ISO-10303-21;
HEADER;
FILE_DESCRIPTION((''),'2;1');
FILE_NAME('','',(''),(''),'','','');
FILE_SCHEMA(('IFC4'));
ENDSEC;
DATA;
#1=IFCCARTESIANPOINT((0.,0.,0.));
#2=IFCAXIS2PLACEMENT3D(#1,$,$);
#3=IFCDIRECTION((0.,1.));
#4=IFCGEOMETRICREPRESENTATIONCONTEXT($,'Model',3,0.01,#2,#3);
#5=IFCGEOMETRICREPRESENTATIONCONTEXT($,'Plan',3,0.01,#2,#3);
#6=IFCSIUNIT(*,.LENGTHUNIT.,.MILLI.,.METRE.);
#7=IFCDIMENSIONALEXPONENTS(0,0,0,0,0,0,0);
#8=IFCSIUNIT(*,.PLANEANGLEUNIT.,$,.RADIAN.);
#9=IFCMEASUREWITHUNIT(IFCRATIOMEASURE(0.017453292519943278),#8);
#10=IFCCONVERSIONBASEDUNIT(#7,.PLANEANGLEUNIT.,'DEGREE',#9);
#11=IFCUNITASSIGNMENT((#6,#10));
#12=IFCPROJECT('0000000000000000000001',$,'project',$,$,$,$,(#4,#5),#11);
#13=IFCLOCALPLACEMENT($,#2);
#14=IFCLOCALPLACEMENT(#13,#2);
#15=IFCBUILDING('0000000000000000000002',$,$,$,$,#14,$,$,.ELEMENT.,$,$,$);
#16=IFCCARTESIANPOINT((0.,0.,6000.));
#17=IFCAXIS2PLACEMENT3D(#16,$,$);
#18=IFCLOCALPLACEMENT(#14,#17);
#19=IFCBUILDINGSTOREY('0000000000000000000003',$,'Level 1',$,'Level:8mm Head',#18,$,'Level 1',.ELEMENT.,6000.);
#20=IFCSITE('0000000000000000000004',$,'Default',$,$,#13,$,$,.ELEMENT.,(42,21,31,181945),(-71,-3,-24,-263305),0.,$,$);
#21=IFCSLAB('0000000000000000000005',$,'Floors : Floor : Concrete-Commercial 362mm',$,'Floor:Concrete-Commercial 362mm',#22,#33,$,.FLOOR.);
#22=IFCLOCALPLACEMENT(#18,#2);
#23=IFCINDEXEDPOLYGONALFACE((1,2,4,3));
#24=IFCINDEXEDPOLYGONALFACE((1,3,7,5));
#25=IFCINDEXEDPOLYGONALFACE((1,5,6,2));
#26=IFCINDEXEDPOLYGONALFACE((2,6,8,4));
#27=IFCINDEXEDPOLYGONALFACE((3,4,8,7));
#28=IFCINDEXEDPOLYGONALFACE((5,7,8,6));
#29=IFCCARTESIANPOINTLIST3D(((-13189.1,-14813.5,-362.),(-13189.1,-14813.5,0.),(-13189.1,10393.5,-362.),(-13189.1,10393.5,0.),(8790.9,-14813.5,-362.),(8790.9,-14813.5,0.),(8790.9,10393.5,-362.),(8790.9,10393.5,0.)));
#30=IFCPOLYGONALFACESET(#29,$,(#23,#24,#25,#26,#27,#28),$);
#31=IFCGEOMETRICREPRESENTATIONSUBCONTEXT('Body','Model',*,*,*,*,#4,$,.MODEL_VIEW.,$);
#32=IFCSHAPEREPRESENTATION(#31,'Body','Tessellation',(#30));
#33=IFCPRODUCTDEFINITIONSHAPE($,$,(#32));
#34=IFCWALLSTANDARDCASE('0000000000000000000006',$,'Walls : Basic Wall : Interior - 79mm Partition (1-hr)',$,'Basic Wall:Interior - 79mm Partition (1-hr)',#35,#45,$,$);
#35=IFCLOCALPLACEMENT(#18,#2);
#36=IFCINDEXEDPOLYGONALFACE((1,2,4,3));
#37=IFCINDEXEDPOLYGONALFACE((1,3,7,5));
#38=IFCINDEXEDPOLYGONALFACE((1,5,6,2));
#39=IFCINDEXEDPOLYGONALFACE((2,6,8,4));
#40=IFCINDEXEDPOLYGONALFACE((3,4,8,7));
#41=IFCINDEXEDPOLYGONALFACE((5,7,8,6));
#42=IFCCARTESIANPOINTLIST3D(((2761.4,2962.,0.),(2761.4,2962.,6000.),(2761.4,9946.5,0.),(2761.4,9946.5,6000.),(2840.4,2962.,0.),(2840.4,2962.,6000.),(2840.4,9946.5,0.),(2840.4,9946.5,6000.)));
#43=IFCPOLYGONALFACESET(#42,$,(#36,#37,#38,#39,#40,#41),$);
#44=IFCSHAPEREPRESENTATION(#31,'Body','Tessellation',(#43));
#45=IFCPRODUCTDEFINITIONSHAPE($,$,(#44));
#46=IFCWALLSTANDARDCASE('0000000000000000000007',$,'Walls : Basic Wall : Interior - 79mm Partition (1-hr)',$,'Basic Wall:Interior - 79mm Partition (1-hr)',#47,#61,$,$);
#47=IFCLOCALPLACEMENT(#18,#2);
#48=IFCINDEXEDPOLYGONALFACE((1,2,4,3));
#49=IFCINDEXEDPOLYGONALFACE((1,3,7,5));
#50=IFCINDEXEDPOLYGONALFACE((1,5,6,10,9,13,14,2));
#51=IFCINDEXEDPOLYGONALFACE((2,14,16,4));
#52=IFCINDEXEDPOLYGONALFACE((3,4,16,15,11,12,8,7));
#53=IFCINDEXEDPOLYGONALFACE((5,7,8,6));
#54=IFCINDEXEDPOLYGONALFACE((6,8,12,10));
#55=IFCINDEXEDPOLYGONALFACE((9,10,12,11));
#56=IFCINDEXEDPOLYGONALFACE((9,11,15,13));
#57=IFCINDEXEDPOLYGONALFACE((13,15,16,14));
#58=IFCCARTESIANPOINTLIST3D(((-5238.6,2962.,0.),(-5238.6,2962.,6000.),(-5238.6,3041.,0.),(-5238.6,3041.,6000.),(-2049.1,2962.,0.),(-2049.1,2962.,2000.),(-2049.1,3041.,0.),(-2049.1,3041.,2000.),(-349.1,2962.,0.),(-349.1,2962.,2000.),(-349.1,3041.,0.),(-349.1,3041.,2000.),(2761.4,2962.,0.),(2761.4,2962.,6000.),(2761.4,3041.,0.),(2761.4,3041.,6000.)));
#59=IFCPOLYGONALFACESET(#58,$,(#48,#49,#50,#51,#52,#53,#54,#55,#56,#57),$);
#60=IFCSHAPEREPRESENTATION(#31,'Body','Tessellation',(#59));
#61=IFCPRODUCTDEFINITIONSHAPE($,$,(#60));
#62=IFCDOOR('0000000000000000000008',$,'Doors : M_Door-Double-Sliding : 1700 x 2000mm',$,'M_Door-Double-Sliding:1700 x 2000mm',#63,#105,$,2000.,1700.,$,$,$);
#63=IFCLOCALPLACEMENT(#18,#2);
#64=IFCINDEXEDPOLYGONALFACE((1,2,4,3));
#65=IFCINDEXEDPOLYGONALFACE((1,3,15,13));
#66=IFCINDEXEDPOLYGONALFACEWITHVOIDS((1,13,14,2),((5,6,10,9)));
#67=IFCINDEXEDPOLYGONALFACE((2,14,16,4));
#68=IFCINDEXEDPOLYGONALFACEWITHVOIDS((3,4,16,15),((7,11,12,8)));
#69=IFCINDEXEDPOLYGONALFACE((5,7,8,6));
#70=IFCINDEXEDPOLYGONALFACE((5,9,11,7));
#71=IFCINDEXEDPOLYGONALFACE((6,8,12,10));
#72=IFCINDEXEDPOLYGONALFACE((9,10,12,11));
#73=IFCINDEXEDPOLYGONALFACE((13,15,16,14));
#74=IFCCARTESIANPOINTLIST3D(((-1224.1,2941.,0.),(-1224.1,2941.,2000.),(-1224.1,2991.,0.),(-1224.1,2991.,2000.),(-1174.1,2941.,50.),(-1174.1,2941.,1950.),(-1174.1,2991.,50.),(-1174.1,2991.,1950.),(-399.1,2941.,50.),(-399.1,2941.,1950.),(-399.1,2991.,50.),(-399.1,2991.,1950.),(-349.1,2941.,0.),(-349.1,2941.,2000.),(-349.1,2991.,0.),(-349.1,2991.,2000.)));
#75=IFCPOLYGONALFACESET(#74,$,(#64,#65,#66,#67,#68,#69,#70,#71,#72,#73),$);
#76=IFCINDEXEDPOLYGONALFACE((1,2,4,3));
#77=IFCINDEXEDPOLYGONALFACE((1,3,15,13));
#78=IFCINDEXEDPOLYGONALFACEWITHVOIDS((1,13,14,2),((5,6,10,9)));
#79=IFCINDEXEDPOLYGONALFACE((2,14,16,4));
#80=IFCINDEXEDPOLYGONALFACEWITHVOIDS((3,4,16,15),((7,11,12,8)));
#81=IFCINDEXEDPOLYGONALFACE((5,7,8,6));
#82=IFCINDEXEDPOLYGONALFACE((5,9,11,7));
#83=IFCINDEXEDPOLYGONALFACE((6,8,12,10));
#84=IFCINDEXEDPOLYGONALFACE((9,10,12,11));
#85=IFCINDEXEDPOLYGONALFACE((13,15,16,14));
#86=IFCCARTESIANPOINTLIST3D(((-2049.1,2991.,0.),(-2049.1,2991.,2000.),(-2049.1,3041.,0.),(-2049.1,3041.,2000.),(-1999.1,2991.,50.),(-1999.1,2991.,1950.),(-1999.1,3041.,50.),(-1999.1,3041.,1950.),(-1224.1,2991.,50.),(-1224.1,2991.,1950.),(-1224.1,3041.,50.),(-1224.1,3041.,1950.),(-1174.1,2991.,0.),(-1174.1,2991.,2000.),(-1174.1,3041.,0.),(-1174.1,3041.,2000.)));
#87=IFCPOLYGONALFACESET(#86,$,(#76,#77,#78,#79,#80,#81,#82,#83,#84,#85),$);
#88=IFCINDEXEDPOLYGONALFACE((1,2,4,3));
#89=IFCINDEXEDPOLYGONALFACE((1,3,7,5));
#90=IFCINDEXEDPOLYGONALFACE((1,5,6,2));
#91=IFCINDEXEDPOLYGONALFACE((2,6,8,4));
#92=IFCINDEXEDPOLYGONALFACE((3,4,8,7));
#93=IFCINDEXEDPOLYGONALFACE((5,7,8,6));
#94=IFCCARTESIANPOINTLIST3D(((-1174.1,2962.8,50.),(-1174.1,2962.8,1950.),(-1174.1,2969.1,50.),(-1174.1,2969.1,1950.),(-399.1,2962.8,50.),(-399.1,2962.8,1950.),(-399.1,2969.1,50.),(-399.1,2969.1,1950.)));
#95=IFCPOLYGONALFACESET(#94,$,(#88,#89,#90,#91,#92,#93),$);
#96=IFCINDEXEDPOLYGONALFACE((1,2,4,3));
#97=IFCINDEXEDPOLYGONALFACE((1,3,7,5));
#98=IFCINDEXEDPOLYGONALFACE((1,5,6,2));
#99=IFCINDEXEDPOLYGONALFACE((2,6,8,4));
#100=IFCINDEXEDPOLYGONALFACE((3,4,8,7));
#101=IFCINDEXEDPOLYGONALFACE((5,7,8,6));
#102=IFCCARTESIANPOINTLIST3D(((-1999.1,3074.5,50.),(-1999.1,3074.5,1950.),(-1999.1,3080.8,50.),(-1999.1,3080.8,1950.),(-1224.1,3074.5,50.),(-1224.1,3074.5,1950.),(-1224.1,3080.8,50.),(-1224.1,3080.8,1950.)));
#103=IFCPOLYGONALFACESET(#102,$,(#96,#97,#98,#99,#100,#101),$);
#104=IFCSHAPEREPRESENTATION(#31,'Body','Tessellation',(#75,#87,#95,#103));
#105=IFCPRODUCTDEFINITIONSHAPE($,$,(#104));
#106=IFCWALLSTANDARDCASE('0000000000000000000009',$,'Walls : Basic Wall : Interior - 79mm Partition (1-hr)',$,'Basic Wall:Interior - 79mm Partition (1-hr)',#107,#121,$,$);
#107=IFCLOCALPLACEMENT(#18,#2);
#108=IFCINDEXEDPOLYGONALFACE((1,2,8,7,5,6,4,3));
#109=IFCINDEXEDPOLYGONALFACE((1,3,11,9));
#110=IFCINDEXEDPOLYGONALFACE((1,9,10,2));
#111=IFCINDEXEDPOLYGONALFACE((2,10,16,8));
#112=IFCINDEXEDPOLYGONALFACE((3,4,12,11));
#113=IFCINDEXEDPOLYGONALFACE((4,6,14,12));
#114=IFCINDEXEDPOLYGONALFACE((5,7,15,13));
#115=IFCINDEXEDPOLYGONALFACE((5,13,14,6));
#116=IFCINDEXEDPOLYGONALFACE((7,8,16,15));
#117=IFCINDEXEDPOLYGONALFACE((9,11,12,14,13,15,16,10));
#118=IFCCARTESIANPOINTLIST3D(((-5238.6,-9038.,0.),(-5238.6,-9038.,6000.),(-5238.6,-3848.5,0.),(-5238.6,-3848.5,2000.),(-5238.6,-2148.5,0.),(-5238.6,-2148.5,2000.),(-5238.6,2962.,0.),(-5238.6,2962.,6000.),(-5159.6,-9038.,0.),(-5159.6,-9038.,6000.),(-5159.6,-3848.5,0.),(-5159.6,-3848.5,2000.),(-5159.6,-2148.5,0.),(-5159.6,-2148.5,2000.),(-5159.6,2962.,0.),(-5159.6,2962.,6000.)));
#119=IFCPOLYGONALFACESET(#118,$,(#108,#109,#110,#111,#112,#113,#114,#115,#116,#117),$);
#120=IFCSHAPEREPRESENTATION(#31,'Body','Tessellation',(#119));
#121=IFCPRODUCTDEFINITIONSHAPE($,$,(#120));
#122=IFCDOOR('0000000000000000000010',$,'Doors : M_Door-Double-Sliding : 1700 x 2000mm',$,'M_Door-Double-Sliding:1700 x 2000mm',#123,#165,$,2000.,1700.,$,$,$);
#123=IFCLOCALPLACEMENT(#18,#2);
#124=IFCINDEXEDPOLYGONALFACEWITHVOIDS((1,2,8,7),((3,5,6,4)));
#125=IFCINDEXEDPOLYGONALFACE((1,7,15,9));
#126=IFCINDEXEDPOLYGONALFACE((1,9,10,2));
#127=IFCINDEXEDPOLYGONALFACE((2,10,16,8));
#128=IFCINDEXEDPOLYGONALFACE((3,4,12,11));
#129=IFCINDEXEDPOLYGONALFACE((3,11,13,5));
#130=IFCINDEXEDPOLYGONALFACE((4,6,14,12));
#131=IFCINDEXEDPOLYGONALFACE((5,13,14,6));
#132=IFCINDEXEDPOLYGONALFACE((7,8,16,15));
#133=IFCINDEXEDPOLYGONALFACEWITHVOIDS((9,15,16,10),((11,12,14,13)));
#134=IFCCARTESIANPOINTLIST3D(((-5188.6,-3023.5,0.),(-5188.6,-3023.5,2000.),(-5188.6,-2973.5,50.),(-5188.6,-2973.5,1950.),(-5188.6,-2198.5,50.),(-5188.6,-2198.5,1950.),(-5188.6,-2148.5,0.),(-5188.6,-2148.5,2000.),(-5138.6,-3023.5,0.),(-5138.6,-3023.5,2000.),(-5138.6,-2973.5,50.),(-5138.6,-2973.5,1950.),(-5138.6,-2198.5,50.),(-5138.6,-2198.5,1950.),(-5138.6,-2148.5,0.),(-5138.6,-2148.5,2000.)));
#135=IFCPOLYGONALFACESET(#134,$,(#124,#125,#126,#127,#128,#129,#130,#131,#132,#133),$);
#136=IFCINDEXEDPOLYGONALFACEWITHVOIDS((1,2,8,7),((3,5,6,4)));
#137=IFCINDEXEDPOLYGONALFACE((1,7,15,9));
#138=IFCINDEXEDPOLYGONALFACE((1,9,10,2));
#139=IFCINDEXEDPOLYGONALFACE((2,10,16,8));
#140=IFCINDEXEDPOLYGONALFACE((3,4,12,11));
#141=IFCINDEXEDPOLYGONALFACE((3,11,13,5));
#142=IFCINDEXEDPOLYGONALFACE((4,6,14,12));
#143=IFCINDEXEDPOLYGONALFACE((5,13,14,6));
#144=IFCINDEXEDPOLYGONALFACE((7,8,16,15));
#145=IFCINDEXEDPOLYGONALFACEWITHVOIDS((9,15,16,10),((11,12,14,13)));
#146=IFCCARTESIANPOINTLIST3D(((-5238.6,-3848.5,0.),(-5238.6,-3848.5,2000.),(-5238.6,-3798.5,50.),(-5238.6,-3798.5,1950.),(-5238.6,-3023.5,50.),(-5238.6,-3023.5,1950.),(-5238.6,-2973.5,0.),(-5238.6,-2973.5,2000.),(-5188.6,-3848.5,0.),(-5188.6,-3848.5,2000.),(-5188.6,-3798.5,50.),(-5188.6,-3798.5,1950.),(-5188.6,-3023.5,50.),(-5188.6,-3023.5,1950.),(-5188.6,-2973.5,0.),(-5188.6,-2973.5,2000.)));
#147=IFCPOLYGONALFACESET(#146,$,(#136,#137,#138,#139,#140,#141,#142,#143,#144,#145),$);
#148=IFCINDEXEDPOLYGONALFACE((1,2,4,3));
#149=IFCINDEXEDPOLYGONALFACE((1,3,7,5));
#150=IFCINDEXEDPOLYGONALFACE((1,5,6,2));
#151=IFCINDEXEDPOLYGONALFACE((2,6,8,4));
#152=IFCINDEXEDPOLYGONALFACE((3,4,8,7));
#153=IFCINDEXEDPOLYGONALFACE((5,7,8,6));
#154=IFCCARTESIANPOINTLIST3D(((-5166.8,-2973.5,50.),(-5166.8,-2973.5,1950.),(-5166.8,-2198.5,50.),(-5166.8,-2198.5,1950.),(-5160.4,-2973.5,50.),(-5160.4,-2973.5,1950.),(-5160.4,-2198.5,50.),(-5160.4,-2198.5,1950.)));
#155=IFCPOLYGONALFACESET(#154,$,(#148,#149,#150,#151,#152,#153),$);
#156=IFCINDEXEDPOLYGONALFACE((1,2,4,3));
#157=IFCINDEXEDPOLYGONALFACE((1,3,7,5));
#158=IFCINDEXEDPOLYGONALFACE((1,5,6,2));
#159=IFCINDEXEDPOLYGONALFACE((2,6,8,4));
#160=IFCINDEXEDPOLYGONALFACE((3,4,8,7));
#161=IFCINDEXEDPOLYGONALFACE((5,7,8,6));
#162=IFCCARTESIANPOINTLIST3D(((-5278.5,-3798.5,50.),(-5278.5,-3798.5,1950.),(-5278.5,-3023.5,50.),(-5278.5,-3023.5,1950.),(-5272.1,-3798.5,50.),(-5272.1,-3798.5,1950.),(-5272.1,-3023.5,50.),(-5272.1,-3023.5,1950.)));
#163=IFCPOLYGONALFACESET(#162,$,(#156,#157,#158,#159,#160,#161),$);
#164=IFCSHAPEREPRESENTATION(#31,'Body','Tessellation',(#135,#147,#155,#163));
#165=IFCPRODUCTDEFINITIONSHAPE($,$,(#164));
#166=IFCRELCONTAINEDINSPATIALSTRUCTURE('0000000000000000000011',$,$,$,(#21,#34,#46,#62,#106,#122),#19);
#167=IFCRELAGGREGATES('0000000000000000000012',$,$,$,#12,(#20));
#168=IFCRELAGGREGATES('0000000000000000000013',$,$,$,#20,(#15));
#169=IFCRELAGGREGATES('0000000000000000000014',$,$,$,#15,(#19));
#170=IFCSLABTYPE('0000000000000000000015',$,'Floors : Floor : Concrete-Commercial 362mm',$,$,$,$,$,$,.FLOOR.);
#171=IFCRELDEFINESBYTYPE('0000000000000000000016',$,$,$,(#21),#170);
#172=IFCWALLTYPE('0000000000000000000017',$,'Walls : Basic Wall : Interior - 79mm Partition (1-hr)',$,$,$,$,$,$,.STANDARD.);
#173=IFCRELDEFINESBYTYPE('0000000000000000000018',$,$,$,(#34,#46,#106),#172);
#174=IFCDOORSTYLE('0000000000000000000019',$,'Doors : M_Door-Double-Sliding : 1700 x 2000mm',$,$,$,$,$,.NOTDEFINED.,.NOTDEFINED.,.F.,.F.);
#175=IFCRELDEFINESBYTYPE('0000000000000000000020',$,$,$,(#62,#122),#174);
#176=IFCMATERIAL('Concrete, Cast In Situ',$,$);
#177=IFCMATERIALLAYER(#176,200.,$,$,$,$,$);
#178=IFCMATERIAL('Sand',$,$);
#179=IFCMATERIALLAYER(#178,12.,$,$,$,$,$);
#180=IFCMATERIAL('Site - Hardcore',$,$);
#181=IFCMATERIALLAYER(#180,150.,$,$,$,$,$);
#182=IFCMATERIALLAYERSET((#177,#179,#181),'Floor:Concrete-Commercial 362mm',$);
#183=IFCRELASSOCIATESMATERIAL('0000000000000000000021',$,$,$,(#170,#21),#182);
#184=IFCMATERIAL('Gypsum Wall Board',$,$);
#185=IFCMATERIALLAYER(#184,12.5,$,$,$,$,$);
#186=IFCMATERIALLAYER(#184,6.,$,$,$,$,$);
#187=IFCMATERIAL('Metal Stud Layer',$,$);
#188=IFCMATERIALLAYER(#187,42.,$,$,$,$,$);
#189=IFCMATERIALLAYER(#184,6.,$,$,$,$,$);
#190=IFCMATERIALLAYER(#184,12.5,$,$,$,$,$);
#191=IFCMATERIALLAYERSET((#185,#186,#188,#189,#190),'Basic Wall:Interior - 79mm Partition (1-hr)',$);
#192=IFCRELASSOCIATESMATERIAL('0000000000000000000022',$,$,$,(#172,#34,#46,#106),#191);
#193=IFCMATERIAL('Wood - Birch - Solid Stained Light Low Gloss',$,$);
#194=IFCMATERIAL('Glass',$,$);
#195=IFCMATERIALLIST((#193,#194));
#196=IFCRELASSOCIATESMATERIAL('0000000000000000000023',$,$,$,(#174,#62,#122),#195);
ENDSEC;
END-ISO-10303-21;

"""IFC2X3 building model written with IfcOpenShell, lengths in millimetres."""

from ifc_helpers import new_model, entity, si_unit, converted_unit, direction, frame, frame_2d, origin, origin_2d_with_axis, place, context, subcontext, project, spatial, polyline, rectangle, outline, extrude, source, transform, mapped, material, material_list, layer, layer_set, layer_usage, type_object, type_shapes, element, fill, save


model = new_model("IFC2X3")

# Units and contexts
model_context = context("Model", 3, precision=0.01, world=origin(), true_north=direction((0.0, 1.0)))
plan_context = context("Plan", 3, precision=0.01, world=origin(), true_north=direction((0.0, 1.0)))
body_context = subcontext(model_context, "Body", "Model", "MODEL_VIEW")
ifc_project = project(units=[si_unit("LENGTHUNIT", "METRE", prefix="MILLI"), converted_unit("PLANEANGLEUNIT", "DEGREE", entity("IfcRatioMeasure", 0.017453292519943278), si_unit("PLANEANGLEUNIT", "RADIAN"), dimensions=[0, 0, 0, 0, 0, 0, 0])], contexts=[model_context, plan_context])

# Site, building, storey
site_placement = place(None, origin())
site = spatial("IfcSite", under=ifc_project, at=site_placement, Name="Default", CompositionType="ELEMENT", RefLatitude=(42, 21, 31, 181945), RefLongitude=(-71, -3, -24, -263305), RefElevation=0.0)
building_placement = place(site_placement, origin())
building = spatial("IfcBuilding", under=site, at=building_placement, CompositionType="ELEMENT")
storey_placement = place(building_placement, frame((0.0, 0.0, 6000.0)))
storey = spatial("IfcBuildingStorey", under=building, at=storey_placement, Name="Level 1", ObjectType="Level:8mm Head", LongName="Level 1", CompositionType="ELEMENT", Elevation=6000.0)

# Slab
ifc_material_1 = material(Name="Concrete, Cast In Situ")
ifc_layer_1 = layer(ifc_material_1, 200.0)
ifc_material_2 = material(Name="Sand")
ifc_layer_2 = layer(ifc_material_2, 12.0)
ifc_material_3 = material(Name="Site - Hardcore")
ifc_layer_3 = layer(ifc_material_3, 150.0)
ifc_layer_set_1 = layer_set([ifc_layer_1, ifc_layer_2, ifc_layer_3], Name="Floor:Concrete-Commercial 362mm")
ifc_layer_usage_1 = layer_usage(ifc_layer_set_1, "AXIS3", "POSITIVE", 0.0)
slab_type = type_object("IfcSlabType", Name="Floors : Floor : Concrete-Commercial 362mm", PredefinedType="FLOOR", material=ifc_layer_set_1)
slab_placement = place(storey_placement, origin())
element("IfcSlab", 1, at=slab_placement, inside=storey, type_object=slab_type, material=ifc_layer_usage_1, Name="Floors : Floor : Concrete-Commercial 362mm", ObjectType="Floor:Concrete-Commercial 362mm", PredefinedType="FLOOR", context=body_context, shape_type="SweptSolid", body=[
    extrude(rectangle(XDim=25207.0, YDim=21980.0, at=frame_2d((0.0, 0.0), x_axis=(1.0, 0.0))), frame((-2199.1, -2210.0, 0.0), z_axis=(0.0, 0.0, -1.0), x_axis=(0.0, 1.0, 0.0)), (0.0, 0.0, 1.0), 362.0),
])

# Wall
ifc_material_4 = material(Name="Gypsum Wall Board")
ifc_layer_4 = layer(ifc_material_4, 12.5)
ifc_layer_5 = layer(ifc_material_4, 6.0)
ifc_material_5 = material(Name="Metal Stud Layer")
ifc_layer_6 = layer(ifc_material_5, 42.0)
ifc_layer_7 = layer(ifc_material_4, 6.0)
ifc_layer_8 = layer(ifc_material_4, 12.5)
ifc_layer_set_2 = layer_set([ifc_layer_4, ifc_layer_5, ifc_layer_6, ifc_layer_7, ifc_layer_8], Name="Basic Wall:Interior - 79mm Partition (1-hr)")
ifc_layer_usage_2 = layer_usage(ifc_layer_set_2, "AXIS2", "NEGATIVE", 39.5)
wall_type = type_object("IfcWallType", Name="Walls : Basic Wall : Interior - 79mm Partition (1-hr)", PredefinedType="STANDARD", material=ifc_layer_set_2)
wall_1_placement = place(storey_placement, frame((2800.9, 9946.5, 0.0), z_axis=(0.0, 0.0, 1.0), x_axis=(0.0, -1.0, 0.0)))
element("IfcWallStandardCase", 2, at=wall_1_placement, inside=storey, type_object=wall_type, material=ifc_layer_usage_2, Name="Walls : Basic Wall : Interior - 79mm Partition (1-hr)", ObjectType="Basic Wall:Interior - 79mm Partition (1-hr)", context=body_context, shape_type="SweptSolid", body=[
    extrude(rectangle(XDim=6984.5, YDim=79.0, at=frame_2d((3492.3, 0.0), x_axis=(-1.0, 0.0))), origin(), (0.0, 0.0, 1.0), 6000.0),
])

# Walls, openings, doors
wall_2_placement = place(storey_placement, frame((2761.4, 3001.5, 0.0), z_axis=(0.0, 0.0, 1.0), x_axis=(-1.0, 0.0, 0.0)))
wall_2 = element("IfcWallStandardCase", 3, at=wall_2_placement, inside=storey, type_object=wall_type, material=ifc_layer_usage_2, Name="Walls : Basic Wall : Interior - 79mm Partition (1-hr)", ObjectType="Basic Wall:Interior - 79mm Partition (1-hr)", context=body_context, shape_type="SweptSolid", body=[
    extrude(rectangle(XDim=8000.0, YDim=79.0, at=frame_2d((4000.0, 0.0), x_axis=(-1.0, 0.0))), origin(), (0.0, 0.0, 1.0), 6000.0),
])
opening_1_placement = place(wall_2_placement, frame((4810.5, 39.5, 0.0)))
opening_1 = element("IfcOpeningElement", 4, at=opening_1_placement, cuts=wall_2, ObjectType="Opening", context=body_context, shape_type="SweptSolid", body=[
    extrude(rectangle(XDim=2000.0, YDim=1700.0, at=frame_2d((1000.0, 850.0), x_axis=(-1.0, 0.0))), frame((0.0, 0.0, 0.0), z_axis=(0.0, -1.0, 0.0), x_axis=(0.0, 0.0, 1.0)), (0.0, 0.0, 1.0), 79.0),
])
ifc_material_6 = material(Name="Wood - Birch - Solid Stained Light Low Gloss")
ifc_material_7 = material(Name="Glass")
ifc_material_list = material_list([ifc_material_6, ifc_material_7])
door_style = type_object("IfcDoorStyle", Name="Doors : M_Door-Double-Sliding : 1700 x 2000mm", ConstructionType="NOTDEFINED", OperationType="NOTDEFINED", ParameterTakesPrecedence=False, Sizeable=False, material=ifc_material_list)
shared_shape_1 = source(origin(), body_context, "Body", "SweptSolid", [
    extrude(outline(polyline([(-437.5, -1000.0), (437.5, -1000.0), (437.5, 1000.0), (-437.5, 1000.0), (-437.5, -1000.0)]), holes=[polyline([(-387.5, -950.0), (-387.5, 950.0), (387.5, 950.0), (387.5, -950.0), (-387.5, -950.0)])]), frame((1262.5, -21.0, 1000.0), z_axis=(0.0, 1.0, 0.0), x_axis=(1.0, 0.0, 0.0)), (0.0, 0.0, 1.0), 50.0),
    extrude(outline(polyline([(-1000.0, -437.5), (1000.0, -437.5), (1000.0, 437.5), (-1000.0, 437.5), (-1000.0, -437.5)]), holes=[polyline([(-950.0, -387.5), (-950.0, 387.5), (950.0, 387.5), (950.0, -387.5), (-950.0, -387.5)])]), frame((437.5, 29.0, 1000.0), z_axis=(0.0, 1.0, 0.0), x_axis=(0.0, 0.0, -1.0)), (0.0, 0.0, 1.0), 50.0),
    extrude(rectangle(XDim=6.3, YDim=775.0, at=frame_2d((0.0, 0.0), x_axis=(1.0, 0.0))), frame((1262.5, 4.0, 50.0), z_axis=(0.0, 0.0, 1.0), x_axis=(0.0, -1.0, 0.0)), (0.0, 0.0, 1.0), 1900.0),
    extrude(rectangle(XDim=6.4, YDim=775.0, at=origin_2d_with_axis()), frame((437.5, 115.7, 50.0), z_axis=(0.0, 0.0, 1.0), x_axis=(0.0, 1.0, 0.0)), (0.0, 0.0, 1.0), 1900.0),
])
type_shapes(door_style, [shared_shape_1])
door_1_placement = place(opening_1_placement, frame((0.0, 0.0, 0.0), z_axis=(0.0, 0.0, 1.0), x_axis=(-1.0, 0.0, 0.0)))
door_1 = element("IfcDoor", 5, at=door_1_placement, inside=storey, type_object=door_style, material=ifc_material_list, Name="Doors : M_Door-Double-Sliding : 1700 x 2000mm", ObjectType="M_Door-Double-Sliding:1700 x 2000mm", OverallHeight=2000.0, OverallWidth=1700.0, context=body_context, shape_type="MappedRepresentation", body=[
    mapped(shared_shape_1, transform((0.0, 0.0, 0.0), scale=1.0)),
])
fill(opening_1, door_1)
wall_3_placement = place(storey_placement, frame((-5199.1, 2962.0, 0.0), z_axis=(0.0, 0.0, 1.0), x_axis=(0.0, -1.0, 0.0)))
wall_3 = element("IfcWallStandardCase", 6, at=wall_3_placement, inside=storey, type_object=wall_type, material=ifc_layer_usage_2, Name="Walls : Basic Wall : Interior - 79mm Partition (1-hr)", ObjectType="Basic Wall:Interior - 79mm Partition (1-hr)", context=body_context, shape_type="SweptSolid", body=[
    extrude(rectangle(XDim=12000.0, YDim=79.0, at=frame_2d((6000.0, 0.0), x_axis=(1.0, 0.0))), origin(), (0.0, 0.0, 1.0), 6000.0),
])
opening_2_placement = place(wall_3_placement, frame((6810.5, 39.5, 0.0)))
opening_2 = element("IfcOpeningElement", 7, at=opening_2_placement, cuts=wall_3, ObjectType="Opening", context=body_context, shape_type="SweptSolid", body=[
    extrude(rectangle(XDim=2000.0, YDim=1700.0, at=frame_2d((1000.0, 850.0), x_axis=(-1.0, 0.0))), frame((0.0, 0.0, 0.0), z_axis=(0.0, -1.0, 0.0), x_axis=(0.0, 0.0, 1.0)), (0.0, 0.0, 1.0), 79.0),
])
door_2_placement = place(opening_2_placement, frame((0.0, 0.0, 0.0), z_axis=(0.0, 0.0, 1.0), x_axis=(-1.0, 0.0, 0.0)))
door_2 = element("IfcDoor", 8, at=door_2_placement, inside=storey, type_object=door_style, material=ifc_material_list, Name="Doors : M_Door-Double-Sliding : 1700 x 2000mm", ObjectType="M_Door-Double-Sliding:1700 x 2000mm", OverallHeight=2000.0, OverallWidth=1700.0, context=body_context, shape_type="MappedRepresentation", body=[
    mapped(shared_shape_1, transform((0.0, 0.0, 0.0), scale=1.0)),
])
fill(opening_2, door_2)

save(model, "model.ifc")
